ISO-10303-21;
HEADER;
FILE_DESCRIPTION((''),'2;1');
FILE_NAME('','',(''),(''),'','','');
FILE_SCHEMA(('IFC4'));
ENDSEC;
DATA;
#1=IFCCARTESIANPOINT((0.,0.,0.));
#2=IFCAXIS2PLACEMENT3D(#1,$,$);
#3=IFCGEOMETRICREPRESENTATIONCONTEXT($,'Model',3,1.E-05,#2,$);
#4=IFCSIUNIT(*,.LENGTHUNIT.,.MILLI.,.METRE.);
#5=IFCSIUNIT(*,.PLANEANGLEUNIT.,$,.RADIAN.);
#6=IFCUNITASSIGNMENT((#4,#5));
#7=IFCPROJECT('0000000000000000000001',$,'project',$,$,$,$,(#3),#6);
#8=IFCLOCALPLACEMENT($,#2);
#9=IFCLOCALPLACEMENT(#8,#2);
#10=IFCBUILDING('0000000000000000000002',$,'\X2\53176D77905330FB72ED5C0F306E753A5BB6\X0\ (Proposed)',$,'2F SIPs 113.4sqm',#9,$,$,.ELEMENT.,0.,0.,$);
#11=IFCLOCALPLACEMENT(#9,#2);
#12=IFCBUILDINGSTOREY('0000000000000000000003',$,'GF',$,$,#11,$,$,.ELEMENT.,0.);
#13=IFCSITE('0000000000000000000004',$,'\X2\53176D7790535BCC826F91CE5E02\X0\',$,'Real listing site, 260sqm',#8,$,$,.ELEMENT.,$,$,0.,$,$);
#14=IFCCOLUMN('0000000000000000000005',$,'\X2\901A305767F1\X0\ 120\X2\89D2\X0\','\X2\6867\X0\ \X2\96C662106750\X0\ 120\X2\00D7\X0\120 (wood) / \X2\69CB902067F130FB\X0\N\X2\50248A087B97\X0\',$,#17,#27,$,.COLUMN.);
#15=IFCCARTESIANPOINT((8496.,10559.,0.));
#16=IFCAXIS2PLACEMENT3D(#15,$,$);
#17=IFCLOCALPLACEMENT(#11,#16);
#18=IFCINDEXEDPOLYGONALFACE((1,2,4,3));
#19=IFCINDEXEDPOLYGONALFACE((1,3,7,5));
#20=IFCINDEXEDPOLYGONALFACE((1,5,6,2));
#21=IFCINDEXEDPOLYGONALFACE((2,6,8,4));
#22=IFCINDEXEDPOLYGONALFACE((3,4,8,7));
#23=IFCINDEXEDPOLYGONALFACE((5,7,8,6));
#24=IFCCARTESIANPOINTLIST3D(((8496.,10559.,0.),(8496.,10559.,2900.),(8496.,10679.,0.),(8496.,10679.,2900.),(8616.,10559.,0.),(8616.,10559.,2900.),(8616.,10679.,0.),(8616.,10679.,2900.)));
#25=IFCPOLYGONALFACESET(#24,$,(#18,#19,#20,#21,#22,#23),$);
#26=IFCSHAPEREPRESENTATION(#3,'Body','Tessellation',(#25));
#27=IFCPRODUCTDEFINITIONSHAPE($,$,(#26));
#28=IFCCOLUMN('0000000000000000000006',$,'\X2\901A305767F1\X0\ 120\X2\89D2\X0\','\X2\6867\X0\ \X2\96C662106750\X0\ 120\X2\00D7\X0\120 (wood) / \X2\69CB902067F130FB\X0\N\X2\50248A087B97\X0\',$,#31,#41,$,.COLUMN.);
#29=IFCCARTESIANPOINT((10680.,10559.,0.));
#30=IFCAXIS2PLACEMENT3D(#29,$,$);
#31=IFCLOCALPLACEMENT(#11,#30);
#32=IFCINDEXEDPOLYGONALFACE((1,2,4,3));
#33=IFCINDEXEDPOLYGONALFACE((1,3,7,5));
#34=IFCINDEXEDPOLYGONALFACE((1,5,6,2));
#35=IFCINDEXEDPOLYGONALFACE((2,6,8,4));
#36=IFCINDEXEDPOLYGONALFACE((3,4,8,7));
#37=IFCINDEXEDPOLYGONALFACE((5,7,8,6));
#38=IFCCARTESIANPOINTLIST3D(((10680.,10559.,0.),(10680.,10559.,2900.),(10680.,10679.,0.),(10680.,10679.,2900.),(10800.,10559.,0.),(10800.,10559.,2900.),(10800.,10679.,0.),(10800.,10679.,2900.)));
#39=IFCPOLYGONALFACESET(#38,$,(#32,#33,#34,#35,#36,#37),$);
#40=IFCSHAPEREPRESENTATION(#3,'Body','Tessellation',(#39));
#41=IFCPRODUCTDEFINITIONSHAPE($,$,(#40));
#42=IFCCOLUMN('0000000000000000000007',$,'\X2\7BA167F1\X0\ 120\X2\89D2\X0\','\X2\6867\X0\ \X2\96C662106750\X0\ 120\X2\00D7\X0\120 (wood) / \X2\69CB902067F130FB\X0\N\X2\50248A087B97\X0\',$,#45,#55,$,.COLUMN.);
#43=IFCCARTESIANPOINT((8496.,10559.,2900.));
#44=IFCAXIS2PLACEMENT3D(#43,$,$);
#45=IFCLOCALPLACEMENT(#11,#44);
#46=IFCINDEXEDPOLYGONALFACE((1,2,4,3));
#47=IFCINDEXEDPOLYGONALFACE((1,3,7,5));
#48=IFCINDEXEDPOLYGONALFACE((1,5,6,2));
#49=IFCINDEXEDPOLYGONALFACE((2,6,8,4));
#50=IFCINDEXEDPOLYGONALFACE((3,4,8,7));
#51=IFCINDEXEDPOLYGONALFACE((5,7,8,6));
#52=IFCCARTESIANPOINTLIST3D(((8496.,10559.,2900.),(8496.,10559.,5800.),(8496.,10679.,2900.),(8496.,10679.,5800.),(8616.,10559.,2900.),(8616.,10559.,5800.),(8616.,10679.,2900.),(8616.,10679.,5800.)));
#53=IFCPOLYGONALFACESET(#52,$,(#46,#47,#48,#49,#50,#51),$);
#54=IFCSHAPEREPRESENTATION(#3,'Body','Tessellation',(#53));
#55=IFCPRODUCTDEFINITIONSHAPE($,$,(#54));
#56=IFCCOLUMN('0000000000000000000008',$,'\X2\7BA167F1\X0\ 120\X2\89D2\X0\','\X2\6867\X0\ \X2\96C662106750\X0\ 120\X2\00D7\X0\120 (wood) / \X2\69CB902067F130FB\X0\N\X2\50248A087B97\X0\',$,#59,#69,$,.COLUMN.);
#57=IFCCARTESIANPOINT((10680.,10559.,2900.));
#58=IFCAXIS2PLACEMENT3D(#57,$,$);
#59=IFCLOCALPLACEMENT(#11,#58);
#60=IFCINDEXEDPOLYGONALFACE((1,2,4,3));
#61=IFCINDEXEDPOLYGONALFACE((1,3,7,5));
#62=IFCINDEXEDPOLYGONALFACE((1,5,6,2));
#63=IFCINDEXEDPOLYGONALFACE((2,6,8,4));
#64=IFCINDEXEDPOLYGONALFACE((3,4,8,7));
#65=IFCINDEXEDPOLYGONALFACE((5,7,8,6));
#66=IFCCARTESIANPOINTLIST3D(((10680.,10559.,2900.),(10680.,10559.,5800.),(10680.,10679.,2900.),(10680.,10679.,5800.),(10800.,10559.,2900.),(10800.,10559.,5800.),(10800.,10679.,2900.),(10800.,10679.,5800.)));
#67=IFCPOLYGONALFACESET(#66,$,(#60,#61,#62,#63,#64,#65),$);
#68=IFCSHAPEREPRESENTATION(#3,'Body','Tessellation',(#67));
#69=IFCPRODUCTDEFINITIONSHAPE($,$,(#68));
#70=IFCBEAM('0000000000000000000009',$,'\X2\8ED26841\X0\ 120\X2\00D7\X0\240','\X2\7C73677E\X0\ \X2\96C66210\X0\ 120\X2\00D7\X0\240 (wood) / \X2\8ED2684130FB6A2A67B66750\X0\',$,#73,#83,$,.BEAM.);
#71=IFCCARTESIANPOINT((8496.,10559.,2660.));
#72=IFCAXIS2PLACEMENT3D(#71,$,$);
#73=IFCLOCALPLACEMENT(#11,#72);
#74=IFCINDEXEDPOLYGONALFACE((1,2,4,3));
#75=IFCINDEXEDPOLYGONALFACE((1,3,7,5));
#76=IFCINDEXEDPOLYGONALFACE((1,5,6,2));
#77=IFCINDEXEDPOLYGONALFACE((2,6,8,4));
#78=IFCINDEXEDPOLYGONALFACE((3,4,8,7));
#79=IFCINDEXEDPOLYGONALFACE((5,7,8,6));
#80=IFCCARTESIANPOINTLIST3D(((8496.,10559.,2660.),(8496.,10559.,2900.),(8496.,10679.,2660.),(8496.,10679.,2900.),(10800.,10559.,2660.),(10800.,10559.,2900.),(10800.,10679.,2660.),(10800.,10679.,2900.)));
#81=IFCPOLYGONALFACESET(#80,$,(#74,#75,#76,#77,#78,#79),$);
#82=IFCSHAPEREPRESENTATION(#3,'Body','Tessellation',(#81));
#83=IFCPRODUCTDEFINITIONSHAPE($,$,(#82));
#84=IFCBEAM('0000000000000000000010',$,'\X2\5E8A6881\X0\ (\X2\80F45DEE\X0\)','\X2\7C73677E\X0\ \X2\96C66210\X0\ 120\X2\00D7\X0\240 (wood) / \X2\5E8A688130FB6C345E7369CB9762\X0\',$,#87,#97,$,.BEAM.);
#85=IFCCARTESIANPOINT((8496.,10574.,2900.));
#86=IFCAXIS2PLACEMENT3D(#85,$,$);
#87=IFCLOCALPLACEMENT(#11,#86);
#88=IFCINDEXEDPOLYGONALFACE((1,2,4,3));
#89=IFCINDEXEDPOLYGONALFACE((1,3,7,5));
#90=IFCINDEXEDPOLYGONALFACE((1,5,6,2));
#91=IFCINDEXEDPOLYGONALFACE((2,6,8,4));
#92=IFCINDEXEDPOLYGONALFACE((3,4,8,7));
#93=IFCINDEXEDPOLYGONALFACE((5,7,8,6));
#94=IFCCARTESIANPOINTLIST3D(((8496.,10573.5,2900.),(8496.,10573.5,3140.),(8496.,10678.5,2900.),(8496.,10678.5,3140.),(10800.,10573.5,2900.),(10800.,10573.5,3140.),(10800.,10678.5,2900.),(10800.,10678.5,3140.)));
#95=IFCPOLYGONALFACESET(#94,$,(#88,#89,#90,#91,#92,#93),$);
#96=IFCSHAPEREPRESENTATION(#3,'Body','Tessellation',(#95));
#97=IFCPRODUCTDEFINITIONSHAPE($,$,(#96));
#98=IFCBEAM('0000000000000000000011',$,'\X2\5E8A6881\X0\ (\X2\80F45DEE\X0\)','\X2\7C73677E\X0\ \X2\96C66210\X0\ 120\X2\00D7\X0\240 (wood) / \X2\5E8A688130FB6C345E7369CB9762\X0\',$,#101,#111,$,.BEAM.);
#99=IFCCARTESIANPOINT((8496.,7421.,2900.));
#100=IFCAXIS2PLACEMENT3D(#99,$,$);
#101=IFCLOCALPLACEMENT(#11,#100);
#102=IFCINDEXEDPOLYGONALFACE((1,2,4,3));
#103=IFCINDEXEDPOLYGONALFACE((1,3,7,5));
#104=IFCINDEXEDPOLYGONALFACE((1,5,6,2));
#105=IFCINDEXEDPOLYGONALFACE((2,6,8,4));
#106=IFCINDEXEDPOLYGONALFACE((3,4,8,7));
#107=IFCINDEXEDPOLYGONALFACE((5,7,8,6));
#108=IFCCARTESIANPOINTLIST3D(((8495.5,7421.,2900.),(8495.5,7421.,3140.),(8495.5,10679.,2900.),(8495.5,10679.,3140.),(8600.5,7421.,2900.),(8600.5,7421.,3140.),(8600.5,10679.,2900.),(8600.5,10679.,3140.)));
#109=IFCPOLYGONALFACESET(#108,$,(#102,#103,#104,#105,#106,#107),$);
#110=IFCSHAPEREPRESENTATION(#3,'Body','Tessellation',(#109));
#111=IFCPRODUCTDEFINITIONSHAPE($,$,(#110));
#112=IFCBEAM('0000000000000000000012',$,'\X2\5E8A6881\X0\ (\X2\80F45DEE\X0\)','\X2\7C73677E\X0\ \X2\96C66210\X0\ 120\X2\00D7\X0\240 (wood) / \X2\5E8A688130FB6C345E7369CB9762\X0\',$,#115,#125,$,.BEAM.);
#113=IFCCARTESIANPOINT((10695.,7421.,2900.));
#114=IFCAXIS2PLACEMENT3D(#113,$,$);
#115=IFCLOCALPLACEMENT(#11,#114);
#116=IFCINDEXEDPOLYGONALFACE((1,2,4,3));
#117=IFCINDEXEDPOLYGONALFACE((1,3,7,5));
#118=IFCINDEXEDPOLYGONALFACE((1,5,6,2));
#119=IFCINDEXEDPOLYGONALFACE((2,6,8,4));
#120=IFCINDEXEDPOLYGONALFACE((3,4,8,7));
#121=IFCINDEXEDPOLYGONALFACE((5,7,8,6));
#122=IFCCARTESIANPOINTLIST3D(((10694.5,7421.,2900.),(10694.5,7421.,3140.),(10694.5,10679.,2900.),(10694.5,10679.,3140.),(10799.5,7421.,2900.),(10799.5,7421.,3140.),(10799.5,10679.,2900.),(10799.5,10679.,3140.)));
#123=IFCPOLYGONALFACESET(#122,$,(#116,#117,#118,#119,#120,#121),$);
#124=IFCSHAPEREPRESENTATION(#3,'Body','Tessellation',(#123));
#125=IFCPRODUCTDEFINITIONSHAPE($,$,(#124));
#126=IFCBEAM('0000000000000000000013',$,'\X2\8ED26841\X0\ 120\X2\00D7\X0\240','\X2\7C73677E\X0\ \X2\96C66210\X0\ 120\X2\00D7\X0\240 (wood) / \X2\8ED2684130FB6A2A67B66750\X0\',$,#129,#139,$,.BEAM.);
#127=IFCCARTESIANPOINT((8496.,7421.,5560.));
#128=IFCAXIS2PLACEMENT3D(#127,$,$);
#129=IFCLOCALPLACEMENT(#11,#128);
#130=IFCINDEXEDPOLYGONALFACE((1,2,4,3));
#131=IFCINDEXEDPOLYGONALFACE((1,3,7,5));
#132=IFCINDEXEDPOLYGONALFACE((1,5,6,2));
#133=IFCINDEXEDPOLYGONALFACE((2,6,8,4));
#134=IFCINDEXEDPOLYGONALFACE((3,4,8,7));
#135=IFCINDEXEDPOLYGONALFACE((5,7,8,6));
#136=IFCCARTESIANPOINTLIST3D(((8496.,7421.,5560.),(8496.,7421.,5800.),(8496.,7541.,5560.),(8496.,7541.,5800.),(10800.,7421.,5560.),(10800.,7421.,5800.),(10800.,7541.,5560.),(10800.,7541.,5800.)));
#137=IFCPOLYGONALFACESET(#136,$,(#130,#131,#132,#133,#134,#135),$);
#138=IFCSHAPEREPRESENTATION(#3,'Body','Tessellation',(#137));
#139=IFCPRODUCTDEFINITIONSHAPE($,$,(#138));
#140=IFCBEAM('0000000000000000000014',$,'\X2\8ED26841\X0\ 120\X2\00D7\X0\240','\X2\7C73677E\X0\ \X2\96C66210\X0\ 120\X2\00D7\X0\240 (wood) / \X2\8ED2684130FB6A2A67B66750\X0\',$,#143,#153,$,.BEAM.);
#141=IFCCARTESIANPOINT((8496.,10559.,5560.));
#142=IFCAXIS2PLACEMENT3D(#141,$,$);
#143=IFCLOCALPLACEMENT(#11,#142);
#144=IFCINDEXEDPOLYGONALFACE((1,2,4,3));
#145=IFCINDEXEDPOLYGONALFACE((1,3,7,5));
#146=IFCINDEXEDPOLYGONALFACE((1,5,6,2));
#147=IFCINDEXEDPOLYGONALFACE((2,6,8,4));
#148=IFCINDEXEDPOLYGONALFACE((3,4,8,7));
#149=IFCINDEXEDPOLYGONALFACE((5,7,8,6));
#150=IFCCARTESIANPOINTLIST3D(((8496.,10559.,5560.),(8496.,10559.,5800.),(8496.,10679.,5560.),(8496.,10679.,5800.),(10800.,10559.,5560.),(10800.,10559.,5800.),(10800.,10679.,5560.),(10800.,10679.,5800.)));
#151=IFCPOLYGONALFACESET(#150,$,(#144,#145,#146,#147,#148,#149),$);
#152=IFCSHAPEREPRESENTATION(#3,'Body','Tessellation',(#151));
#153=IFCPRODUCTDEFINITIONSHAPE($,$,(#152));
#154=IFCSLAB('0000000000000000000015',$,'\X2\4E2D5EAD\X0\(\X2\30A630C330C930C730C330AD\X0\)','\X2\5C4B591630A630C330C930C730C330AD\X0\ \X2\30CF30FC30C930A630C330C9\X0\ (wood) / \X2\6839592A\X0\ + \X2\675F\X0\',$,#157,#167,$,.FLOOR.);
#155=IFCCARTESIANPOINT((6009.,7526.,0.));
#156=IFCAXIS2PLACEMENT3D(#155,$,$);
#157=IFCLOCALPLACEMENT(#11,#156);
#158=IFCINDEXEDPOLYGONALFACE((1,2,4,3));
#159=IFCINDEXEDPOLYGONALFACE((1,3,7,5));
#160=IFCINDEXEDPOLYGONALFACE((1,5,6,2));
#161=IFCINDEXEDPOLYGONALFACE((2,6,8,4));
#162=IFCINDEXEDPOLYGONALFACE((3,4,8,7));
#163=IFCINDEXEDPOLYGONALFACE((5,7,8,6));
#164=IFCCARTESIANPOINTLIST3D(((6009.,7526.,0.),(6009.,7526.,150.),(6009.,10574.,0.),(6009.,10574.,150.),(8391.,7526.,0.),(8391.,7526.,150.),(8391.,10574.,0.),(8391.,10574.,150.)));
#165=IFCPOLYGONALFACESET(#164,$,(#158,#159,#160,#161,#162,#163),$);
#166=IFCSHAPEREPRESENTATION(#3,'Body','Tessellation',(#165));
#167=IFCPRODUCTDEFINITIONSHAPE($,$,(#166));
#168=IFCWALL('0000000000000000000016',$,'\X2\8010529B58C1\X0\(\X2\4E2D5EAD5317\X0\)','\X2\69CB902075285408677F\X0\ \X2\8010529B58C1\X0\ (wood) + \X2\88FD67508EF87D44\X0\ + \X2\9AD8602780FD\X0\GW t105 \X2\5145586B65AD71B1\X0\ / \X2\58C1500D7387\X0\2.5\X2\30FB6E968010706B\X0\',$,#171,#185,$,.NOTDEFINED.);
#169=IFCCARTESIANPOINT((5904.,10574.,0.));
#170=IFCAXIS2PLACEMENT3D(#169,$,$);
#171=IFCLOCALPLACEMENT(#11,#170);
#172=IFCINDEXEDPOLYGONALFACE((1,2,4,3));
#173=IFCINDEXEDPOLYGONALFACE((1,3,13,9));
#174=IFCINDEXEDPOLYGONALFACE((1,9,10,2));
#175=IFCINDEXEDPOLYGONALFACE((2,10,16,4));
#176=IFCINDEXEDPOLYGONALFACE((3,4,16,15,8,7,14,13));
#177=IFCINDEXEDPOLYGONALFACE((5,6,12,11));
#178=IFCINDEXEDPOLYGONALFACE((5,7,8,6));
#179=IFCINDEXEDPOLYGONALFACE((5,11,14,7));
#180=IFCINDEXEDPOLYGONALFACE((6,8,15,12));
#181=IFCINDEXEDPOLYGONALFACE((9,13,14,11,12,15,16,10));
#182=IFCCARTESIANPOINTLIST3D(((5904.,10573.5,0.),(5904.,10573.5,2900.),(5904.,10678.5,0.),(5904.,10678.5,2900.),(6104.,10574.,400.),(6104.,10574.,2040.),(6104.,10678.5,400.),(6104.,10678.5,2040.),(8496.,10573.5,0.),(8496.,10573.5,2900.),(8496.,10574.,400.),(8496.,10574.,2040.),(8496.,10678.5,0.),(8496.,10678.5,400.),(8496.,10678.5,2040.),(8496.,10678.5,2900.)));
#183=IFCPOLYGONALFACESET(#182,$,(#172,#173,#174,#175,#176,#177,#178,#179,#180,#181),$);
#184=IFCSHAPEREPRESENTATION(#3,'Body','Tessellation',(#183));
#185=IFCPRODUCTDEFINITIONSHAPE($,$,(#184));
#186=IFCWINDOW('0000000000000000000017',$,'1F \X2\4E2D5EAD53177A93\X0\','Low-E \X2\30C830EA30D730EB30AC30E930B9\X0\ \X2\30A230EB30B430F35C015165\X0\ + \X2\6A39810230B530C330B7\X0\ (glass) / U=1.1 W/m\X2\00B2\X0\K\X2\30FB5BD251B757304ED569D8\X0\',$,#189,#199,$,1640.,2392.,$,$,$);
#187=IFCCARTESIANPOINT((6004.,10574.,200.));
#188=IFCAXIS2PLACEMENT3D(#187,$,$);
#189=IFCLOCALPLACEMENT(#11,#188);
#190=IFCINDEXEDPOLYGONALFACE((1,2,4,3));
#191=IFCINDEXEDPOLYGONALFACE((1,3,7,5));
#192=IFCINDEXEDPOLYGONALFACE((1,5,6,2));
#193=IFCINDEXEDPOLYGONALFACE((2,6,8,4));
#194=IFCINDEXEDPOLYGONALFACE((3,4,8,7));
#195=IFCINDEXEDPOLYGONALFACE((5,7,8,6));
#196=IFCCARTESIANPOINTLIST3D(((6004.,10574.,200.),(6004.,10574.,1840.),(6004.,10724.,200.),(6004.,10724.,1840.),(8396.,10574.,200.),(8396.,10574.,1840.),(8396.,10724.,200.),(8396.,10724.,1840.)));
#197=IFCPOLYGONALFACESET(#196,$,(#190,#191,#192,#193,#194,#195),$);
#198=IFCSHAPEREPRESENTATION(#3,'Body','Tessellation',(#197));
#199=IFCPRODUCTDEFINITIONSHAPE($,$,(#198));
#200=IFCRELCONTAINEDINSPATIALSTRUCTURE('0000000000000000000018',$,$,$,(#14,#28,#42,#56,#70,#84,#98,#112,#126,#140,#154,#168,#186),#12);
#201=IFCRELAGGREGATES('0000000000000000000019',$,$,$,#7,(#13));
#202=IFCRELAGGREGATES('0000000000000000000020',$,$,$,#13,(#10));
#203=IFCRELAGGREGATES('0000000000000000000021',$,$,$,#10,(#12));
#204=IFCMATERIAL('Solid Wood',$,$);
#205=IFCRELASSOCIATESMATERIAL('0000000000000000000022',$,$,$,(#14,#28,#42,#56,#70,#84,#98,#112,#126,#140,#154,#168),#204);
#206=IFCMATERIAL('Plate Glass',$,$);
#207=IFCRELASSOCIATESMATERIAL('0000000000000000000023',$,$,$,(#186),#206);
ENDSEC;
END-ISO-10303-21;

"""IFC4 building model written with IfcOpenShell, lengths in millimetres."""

from ifc_helpers import new_model, si_unit, frame, frame_2d, origin, place, context, project, spatial, rectangle, extrude, material, element, fill, save


model = new_model("IFC4")

# Units and contexts
model_context = context("Model", 3, precision=1e-05, world=origin())
ifc_project = project(units=[si_unit("LENGTHUNIT", "METRE", prefix="MILLI"), si_unit("PLANEANGLEUNIT", "RADIAN")], contexts=[model_context])

# Site, building, storey
site_placement = place(None, origin())
site = spatial("IfcSite", under=ifc_project, at=site_placement, Name="北海道富良野市", ObjectType="Real listing site, 260sqm", CompositionType="ELEMENT", RefElevation=0.0)
building_placement = place(site_placement, origin())
building = spatial("IfcBuilding", under=site, at=building_placement, Name="北海道・狭小の町家 (Proposed)", ObjectType="2F SIPs 113.4sqm", CompositionType="ELEMENT", ElevationOfRefHeight=0.0, ElevationOfTerrain=0.0)
storey_placement = place(building_placement, origin())
storey = spatial("IfcBuildingStorey", under=building, at=storey_placement, Name="GF", CompositionType="ELEMENT", Elevation=0.0)

# Columns
ifc_material_1 = material(Name="Solid Wood")
column_1_placement = place(storey_placement, frame((8496.0, 10559.0, 0.0)))
element("IfcColumn", 1, at=column_1_placement, inside=storey, material=ifc_material_1, Name="通し柱 120角", Description="桧 集成材 120×120 (wood) / 構造柱・N値計算", PredefinedType="COLUMN", context=model_context, shape_type="SweptSolid", body=[
    extrude(rectangle(XDim=120.0, YDim=120.0, at=frame_2d((60.0, 60.0))), frame((8496.0, 10559.0, 0.0)), (0.0, 0.0, 1.0), 2900.0),
])
column_2_placement = place(storey_placement, frame((10680.0, 10559.0, 0.0)))
element("IfcColumn", 2, at=column_2_placement, inside=storey, material=ifc_material_1, Name="通し柱 120角", Description="桧 集成材 120×120 (wood) / 構造柱・N値計算", PredefinedType="COLUMN", context=model_context, shape_type="SweptSolid", body=[
    extrude(rectangle(XDim=120.0, YDim=120.0, at=frame_2d((60.0, 60.0))), frame((10680.0, 10559.0, 0.0)), (0.0, 0.0, 1.0), 2900.0),
])
column_3_placement = place(storey_placement, frame((8496.0, 10559.0, 2900.0)))
element("IfcColumn", 3, at=column_3_placement, inside=storey, material=ifc_material_1, Name="管柱 120角", Description="桧 集成材 120×120 (wood) / 構造柱・N値計算", PredefinedType="COLUMN", context=model_context, shape_type="SweptSolid", body=[
    extrude(rectangle(XDim=120.0, YDim=120.0, at=frame_2d((60.0, 60.0))), frame((8496.0, 10559.0, 2900.0)), (0.0, 0.0, 1.0), 2900.0),
])
column_4_placement = place(storey_placement, frame((10680.0, 10559.0, 2900.0)))
element("IfcColumn", 4, at=column_4_placement, inside=storey, material=ifc_material_1, Name="管柱 120角", Description="桧 集成材 120×120 (wood) / 構造柱・N値計算", PredefinedType="COLUMN", context=model_context, shape_type="SweptSolid", body=[
    extrude(rectangle(XDim=120.0, YDim=120.0, at=frame_2d((60.0, 60.0))), frame((10680.0, 10559.0, 2900.0)), (0.0, 0.0, 1.0), 2900.0),
])

# Beams
beam_1_placement = place(storey_placement, frame((8496.0, 10559.0, 2660.0)))
element("IfcBeam", 5, at=beam_1_placement, inside=storey, material=ifc_material_1, Name="軒桁 120×240", Description="米松 集成 120×240 (wood) / 軒桁・横架材", PredefinedType="BEAM", context=model_context, shape_type="SweptSolid", body=[
    extrude(rectangle(XDim=2304.0, YDim=120.0, at=frame_2d((1152.0, 60.0))), frame((8496.0, 10559.0, 2660.0)), (0.0, 0.0, 1.0), 240.0),
])
beam_2_placement = place(storey_placement, frame((8496.0, 10574.0, 2900.0)))
element("IfcBeam", 6, at=beam_2_placement, inside=storey, material=ifc_material_1, Name="床梁 (胴差)", Description="米松 集成 120×240 (wood) / 床梁・水平構面", PredefinedType="BEAM", context=model_context, shape_type="SweptSolid", body=[
    extrude(rectangle(XDim=2304.0, YDim=105.0, at=frame_2d((1152.0, 52.0))), frame((8496.0, 10574.0, 2900.0)), (0.0, 0.0, 1.0), 240.0),
])
beam_3_placement = place(storey_placement, frame((8496.0, 7421.0, 2900.0)))
element("IfcBeam", 7, at=beam_3_placement, inside=storey, material=ifc_material_1, Name="床梁 (胴差)", Description="米松 集成 120×240 (wood) / 床梁・水平構面", PredefinedType="BEAM", context=model_context, shape_type="SweptSolid", body=[
    extrude(rectangle(XDim=105.0, YDim=3258.0, at=frame_2d((52.0, 1629.0))), frame((8496.0, 7421.0, 2900.0)), (0.0, 0.0, 1.0), 240.0),
])
beam_4_placement = place(storey_placement, frame((10695.0, 7421.0, 2900.0)))
element("IfcBeam", 8, at=beam_4_placement, inside=storey, material=ifc_material_1, Name="床梁 (胴差)", Description="米松 集成 120×240 (wood) / 床梁・水平構面", PredefinedType="BEAM", context=model_context, shape_type="SweptSolid", body=[
    extrude(rectangle(XDim=105.0, YDim=3258.0, at=frame_2d((52.0, 1629.0))), frame((10695.0, 7421.0, 2900.0)), (0.0, 0.0, 1.0), 240.0),
])
beam_5_placement = place(storey_placement, frame((8496.0, 7421.0, 5560.0)))
element("IfcBeam", 9, at=beam_5_placement, inside=storey, material=ifc_material_1, Name="軒桁 120×240", Description="米松 集成 120×240 (wood) / 軒桁・横架材", PredefinedType="BEAM", context=model_context, shape_type="SweptSolid", body=[
    extrude(rectangle(XDim=2304.0, YDim=120.0, at=frame_2d((1152.0, 60.0))), frame((8496.0, 7421.0, 5560.0)), (0.0, 0.0, 1.0), 240.0),
])
beam_6_placement = place(storey_placement, frame((8496.0, 10559.0, 5560.0)))
element("IfcBeam", 10, at=beam_6_placement, inside=storey, material=ifc_material_1, Name="軒桁 120×240", Description="米松 集成 120×240 (wood) / 軒桁・横架材", PredefinedType="BEAM", context=model_context, shape_type="SweptSolid", body=[
    extrude(rectangle(XDim=2304.0, YDim=120.0, at=frame_2d((1152.0, 60.0))), frame((8496.0, 10559.0, 5560.0)), (0.0, 0.0, 1.0), 240.0),
])

# Slab
slab_placement = place(storey_placement, frame((6009.0, 7526.0, 0.0)))
element("IfcSlab", 11, at=slab_placement, inside=storey, material=ifc_material_1, Name="中庭(ウッドデッキ)", Description="屋外ウッドデッキ ハードウッド (wood) / 根太 + 束", PredefinedType="FLOOR", context=model_context, shape_type="SweptSolid", body=[
    extrude(rectangle(XDim=2382.0, YDim=3048.0, at=frame_2d((1191.0, 1524.0))), frame((6009.0, 7526.0, 0.0)), (0.0, 0.0, 1.0), 150.0),
])

# Wall, opening, window
wall_1_placement = place(storey_placement, frame((5904.0, 10574.0, 0.0)))
wall_1 = element("IfcWall", 12, at=wall_1_placement, inside=storey, material=ifc_material_1, Name="耐力壁(中庭北)", Description="構造用合板 耐力壁 (wood) + 製材軸組 + 高性能GW t105 充填断熱 / 壁倍率2.5・準耐火", PredefinedType="NOTDEFINED", context=model_context, shape_type="SweptSolid", body=[
    extrude(rectangle(XDim=2592.0, YDim=105.0, at=frame_2d((1296.0, 52.0))), frame((5904.0, 10574.0, 0.0)), (0.0, 0.0, 1.0), 2900.0),
])
opening_1_placement = place(storey_placement, frame((6004.0, 10574.0, 200.0)))
opening_1 = element("IfcOpeningElement", 13, at=opening_1_placement, cuts=wall_1, PredefinedType="NOTDEFINED", context=model_context, shape_type="SweptSolid", body=[
    extrude(rectangle(XDim=2392.0, YDim=150.0, at=frame_2d((1196.0, 75.0))), frame((6004.0, 10574.0, 200.0)), (0.0, 0.0, 1.0), 1640.0),
])
ifc_material_2 = material(Name="Plate Glass")
window_1_placement = place(storey_placement, frame((6004.0, 10574.0, 200.0)))
window_1 = element("IfcWindow", 14, at=window_1_placement, inside=storey, material=ifc_material_2, Name="1F 中庭北窓", Description="Low-E トリプルガラス アルゴン封入 + 樹脂サッシ (glass) / U=1.1 W/m²K・寒冷地仕様", OverallHeight=1640.0, OverallWidth=2392.0, context=model_context, shape_type="SweptSolid", body=[
    extrude(rectangle(XDim=2392.0, YDim=150.0, at=frame_2d((1196.0, 75.0))), frame((6004.0, 10574.0, 200.0)), (0.0, 0.0, 1.0), 1640.0),
])
fill(opening_1, window_1)

save(model, "model.ifc")
